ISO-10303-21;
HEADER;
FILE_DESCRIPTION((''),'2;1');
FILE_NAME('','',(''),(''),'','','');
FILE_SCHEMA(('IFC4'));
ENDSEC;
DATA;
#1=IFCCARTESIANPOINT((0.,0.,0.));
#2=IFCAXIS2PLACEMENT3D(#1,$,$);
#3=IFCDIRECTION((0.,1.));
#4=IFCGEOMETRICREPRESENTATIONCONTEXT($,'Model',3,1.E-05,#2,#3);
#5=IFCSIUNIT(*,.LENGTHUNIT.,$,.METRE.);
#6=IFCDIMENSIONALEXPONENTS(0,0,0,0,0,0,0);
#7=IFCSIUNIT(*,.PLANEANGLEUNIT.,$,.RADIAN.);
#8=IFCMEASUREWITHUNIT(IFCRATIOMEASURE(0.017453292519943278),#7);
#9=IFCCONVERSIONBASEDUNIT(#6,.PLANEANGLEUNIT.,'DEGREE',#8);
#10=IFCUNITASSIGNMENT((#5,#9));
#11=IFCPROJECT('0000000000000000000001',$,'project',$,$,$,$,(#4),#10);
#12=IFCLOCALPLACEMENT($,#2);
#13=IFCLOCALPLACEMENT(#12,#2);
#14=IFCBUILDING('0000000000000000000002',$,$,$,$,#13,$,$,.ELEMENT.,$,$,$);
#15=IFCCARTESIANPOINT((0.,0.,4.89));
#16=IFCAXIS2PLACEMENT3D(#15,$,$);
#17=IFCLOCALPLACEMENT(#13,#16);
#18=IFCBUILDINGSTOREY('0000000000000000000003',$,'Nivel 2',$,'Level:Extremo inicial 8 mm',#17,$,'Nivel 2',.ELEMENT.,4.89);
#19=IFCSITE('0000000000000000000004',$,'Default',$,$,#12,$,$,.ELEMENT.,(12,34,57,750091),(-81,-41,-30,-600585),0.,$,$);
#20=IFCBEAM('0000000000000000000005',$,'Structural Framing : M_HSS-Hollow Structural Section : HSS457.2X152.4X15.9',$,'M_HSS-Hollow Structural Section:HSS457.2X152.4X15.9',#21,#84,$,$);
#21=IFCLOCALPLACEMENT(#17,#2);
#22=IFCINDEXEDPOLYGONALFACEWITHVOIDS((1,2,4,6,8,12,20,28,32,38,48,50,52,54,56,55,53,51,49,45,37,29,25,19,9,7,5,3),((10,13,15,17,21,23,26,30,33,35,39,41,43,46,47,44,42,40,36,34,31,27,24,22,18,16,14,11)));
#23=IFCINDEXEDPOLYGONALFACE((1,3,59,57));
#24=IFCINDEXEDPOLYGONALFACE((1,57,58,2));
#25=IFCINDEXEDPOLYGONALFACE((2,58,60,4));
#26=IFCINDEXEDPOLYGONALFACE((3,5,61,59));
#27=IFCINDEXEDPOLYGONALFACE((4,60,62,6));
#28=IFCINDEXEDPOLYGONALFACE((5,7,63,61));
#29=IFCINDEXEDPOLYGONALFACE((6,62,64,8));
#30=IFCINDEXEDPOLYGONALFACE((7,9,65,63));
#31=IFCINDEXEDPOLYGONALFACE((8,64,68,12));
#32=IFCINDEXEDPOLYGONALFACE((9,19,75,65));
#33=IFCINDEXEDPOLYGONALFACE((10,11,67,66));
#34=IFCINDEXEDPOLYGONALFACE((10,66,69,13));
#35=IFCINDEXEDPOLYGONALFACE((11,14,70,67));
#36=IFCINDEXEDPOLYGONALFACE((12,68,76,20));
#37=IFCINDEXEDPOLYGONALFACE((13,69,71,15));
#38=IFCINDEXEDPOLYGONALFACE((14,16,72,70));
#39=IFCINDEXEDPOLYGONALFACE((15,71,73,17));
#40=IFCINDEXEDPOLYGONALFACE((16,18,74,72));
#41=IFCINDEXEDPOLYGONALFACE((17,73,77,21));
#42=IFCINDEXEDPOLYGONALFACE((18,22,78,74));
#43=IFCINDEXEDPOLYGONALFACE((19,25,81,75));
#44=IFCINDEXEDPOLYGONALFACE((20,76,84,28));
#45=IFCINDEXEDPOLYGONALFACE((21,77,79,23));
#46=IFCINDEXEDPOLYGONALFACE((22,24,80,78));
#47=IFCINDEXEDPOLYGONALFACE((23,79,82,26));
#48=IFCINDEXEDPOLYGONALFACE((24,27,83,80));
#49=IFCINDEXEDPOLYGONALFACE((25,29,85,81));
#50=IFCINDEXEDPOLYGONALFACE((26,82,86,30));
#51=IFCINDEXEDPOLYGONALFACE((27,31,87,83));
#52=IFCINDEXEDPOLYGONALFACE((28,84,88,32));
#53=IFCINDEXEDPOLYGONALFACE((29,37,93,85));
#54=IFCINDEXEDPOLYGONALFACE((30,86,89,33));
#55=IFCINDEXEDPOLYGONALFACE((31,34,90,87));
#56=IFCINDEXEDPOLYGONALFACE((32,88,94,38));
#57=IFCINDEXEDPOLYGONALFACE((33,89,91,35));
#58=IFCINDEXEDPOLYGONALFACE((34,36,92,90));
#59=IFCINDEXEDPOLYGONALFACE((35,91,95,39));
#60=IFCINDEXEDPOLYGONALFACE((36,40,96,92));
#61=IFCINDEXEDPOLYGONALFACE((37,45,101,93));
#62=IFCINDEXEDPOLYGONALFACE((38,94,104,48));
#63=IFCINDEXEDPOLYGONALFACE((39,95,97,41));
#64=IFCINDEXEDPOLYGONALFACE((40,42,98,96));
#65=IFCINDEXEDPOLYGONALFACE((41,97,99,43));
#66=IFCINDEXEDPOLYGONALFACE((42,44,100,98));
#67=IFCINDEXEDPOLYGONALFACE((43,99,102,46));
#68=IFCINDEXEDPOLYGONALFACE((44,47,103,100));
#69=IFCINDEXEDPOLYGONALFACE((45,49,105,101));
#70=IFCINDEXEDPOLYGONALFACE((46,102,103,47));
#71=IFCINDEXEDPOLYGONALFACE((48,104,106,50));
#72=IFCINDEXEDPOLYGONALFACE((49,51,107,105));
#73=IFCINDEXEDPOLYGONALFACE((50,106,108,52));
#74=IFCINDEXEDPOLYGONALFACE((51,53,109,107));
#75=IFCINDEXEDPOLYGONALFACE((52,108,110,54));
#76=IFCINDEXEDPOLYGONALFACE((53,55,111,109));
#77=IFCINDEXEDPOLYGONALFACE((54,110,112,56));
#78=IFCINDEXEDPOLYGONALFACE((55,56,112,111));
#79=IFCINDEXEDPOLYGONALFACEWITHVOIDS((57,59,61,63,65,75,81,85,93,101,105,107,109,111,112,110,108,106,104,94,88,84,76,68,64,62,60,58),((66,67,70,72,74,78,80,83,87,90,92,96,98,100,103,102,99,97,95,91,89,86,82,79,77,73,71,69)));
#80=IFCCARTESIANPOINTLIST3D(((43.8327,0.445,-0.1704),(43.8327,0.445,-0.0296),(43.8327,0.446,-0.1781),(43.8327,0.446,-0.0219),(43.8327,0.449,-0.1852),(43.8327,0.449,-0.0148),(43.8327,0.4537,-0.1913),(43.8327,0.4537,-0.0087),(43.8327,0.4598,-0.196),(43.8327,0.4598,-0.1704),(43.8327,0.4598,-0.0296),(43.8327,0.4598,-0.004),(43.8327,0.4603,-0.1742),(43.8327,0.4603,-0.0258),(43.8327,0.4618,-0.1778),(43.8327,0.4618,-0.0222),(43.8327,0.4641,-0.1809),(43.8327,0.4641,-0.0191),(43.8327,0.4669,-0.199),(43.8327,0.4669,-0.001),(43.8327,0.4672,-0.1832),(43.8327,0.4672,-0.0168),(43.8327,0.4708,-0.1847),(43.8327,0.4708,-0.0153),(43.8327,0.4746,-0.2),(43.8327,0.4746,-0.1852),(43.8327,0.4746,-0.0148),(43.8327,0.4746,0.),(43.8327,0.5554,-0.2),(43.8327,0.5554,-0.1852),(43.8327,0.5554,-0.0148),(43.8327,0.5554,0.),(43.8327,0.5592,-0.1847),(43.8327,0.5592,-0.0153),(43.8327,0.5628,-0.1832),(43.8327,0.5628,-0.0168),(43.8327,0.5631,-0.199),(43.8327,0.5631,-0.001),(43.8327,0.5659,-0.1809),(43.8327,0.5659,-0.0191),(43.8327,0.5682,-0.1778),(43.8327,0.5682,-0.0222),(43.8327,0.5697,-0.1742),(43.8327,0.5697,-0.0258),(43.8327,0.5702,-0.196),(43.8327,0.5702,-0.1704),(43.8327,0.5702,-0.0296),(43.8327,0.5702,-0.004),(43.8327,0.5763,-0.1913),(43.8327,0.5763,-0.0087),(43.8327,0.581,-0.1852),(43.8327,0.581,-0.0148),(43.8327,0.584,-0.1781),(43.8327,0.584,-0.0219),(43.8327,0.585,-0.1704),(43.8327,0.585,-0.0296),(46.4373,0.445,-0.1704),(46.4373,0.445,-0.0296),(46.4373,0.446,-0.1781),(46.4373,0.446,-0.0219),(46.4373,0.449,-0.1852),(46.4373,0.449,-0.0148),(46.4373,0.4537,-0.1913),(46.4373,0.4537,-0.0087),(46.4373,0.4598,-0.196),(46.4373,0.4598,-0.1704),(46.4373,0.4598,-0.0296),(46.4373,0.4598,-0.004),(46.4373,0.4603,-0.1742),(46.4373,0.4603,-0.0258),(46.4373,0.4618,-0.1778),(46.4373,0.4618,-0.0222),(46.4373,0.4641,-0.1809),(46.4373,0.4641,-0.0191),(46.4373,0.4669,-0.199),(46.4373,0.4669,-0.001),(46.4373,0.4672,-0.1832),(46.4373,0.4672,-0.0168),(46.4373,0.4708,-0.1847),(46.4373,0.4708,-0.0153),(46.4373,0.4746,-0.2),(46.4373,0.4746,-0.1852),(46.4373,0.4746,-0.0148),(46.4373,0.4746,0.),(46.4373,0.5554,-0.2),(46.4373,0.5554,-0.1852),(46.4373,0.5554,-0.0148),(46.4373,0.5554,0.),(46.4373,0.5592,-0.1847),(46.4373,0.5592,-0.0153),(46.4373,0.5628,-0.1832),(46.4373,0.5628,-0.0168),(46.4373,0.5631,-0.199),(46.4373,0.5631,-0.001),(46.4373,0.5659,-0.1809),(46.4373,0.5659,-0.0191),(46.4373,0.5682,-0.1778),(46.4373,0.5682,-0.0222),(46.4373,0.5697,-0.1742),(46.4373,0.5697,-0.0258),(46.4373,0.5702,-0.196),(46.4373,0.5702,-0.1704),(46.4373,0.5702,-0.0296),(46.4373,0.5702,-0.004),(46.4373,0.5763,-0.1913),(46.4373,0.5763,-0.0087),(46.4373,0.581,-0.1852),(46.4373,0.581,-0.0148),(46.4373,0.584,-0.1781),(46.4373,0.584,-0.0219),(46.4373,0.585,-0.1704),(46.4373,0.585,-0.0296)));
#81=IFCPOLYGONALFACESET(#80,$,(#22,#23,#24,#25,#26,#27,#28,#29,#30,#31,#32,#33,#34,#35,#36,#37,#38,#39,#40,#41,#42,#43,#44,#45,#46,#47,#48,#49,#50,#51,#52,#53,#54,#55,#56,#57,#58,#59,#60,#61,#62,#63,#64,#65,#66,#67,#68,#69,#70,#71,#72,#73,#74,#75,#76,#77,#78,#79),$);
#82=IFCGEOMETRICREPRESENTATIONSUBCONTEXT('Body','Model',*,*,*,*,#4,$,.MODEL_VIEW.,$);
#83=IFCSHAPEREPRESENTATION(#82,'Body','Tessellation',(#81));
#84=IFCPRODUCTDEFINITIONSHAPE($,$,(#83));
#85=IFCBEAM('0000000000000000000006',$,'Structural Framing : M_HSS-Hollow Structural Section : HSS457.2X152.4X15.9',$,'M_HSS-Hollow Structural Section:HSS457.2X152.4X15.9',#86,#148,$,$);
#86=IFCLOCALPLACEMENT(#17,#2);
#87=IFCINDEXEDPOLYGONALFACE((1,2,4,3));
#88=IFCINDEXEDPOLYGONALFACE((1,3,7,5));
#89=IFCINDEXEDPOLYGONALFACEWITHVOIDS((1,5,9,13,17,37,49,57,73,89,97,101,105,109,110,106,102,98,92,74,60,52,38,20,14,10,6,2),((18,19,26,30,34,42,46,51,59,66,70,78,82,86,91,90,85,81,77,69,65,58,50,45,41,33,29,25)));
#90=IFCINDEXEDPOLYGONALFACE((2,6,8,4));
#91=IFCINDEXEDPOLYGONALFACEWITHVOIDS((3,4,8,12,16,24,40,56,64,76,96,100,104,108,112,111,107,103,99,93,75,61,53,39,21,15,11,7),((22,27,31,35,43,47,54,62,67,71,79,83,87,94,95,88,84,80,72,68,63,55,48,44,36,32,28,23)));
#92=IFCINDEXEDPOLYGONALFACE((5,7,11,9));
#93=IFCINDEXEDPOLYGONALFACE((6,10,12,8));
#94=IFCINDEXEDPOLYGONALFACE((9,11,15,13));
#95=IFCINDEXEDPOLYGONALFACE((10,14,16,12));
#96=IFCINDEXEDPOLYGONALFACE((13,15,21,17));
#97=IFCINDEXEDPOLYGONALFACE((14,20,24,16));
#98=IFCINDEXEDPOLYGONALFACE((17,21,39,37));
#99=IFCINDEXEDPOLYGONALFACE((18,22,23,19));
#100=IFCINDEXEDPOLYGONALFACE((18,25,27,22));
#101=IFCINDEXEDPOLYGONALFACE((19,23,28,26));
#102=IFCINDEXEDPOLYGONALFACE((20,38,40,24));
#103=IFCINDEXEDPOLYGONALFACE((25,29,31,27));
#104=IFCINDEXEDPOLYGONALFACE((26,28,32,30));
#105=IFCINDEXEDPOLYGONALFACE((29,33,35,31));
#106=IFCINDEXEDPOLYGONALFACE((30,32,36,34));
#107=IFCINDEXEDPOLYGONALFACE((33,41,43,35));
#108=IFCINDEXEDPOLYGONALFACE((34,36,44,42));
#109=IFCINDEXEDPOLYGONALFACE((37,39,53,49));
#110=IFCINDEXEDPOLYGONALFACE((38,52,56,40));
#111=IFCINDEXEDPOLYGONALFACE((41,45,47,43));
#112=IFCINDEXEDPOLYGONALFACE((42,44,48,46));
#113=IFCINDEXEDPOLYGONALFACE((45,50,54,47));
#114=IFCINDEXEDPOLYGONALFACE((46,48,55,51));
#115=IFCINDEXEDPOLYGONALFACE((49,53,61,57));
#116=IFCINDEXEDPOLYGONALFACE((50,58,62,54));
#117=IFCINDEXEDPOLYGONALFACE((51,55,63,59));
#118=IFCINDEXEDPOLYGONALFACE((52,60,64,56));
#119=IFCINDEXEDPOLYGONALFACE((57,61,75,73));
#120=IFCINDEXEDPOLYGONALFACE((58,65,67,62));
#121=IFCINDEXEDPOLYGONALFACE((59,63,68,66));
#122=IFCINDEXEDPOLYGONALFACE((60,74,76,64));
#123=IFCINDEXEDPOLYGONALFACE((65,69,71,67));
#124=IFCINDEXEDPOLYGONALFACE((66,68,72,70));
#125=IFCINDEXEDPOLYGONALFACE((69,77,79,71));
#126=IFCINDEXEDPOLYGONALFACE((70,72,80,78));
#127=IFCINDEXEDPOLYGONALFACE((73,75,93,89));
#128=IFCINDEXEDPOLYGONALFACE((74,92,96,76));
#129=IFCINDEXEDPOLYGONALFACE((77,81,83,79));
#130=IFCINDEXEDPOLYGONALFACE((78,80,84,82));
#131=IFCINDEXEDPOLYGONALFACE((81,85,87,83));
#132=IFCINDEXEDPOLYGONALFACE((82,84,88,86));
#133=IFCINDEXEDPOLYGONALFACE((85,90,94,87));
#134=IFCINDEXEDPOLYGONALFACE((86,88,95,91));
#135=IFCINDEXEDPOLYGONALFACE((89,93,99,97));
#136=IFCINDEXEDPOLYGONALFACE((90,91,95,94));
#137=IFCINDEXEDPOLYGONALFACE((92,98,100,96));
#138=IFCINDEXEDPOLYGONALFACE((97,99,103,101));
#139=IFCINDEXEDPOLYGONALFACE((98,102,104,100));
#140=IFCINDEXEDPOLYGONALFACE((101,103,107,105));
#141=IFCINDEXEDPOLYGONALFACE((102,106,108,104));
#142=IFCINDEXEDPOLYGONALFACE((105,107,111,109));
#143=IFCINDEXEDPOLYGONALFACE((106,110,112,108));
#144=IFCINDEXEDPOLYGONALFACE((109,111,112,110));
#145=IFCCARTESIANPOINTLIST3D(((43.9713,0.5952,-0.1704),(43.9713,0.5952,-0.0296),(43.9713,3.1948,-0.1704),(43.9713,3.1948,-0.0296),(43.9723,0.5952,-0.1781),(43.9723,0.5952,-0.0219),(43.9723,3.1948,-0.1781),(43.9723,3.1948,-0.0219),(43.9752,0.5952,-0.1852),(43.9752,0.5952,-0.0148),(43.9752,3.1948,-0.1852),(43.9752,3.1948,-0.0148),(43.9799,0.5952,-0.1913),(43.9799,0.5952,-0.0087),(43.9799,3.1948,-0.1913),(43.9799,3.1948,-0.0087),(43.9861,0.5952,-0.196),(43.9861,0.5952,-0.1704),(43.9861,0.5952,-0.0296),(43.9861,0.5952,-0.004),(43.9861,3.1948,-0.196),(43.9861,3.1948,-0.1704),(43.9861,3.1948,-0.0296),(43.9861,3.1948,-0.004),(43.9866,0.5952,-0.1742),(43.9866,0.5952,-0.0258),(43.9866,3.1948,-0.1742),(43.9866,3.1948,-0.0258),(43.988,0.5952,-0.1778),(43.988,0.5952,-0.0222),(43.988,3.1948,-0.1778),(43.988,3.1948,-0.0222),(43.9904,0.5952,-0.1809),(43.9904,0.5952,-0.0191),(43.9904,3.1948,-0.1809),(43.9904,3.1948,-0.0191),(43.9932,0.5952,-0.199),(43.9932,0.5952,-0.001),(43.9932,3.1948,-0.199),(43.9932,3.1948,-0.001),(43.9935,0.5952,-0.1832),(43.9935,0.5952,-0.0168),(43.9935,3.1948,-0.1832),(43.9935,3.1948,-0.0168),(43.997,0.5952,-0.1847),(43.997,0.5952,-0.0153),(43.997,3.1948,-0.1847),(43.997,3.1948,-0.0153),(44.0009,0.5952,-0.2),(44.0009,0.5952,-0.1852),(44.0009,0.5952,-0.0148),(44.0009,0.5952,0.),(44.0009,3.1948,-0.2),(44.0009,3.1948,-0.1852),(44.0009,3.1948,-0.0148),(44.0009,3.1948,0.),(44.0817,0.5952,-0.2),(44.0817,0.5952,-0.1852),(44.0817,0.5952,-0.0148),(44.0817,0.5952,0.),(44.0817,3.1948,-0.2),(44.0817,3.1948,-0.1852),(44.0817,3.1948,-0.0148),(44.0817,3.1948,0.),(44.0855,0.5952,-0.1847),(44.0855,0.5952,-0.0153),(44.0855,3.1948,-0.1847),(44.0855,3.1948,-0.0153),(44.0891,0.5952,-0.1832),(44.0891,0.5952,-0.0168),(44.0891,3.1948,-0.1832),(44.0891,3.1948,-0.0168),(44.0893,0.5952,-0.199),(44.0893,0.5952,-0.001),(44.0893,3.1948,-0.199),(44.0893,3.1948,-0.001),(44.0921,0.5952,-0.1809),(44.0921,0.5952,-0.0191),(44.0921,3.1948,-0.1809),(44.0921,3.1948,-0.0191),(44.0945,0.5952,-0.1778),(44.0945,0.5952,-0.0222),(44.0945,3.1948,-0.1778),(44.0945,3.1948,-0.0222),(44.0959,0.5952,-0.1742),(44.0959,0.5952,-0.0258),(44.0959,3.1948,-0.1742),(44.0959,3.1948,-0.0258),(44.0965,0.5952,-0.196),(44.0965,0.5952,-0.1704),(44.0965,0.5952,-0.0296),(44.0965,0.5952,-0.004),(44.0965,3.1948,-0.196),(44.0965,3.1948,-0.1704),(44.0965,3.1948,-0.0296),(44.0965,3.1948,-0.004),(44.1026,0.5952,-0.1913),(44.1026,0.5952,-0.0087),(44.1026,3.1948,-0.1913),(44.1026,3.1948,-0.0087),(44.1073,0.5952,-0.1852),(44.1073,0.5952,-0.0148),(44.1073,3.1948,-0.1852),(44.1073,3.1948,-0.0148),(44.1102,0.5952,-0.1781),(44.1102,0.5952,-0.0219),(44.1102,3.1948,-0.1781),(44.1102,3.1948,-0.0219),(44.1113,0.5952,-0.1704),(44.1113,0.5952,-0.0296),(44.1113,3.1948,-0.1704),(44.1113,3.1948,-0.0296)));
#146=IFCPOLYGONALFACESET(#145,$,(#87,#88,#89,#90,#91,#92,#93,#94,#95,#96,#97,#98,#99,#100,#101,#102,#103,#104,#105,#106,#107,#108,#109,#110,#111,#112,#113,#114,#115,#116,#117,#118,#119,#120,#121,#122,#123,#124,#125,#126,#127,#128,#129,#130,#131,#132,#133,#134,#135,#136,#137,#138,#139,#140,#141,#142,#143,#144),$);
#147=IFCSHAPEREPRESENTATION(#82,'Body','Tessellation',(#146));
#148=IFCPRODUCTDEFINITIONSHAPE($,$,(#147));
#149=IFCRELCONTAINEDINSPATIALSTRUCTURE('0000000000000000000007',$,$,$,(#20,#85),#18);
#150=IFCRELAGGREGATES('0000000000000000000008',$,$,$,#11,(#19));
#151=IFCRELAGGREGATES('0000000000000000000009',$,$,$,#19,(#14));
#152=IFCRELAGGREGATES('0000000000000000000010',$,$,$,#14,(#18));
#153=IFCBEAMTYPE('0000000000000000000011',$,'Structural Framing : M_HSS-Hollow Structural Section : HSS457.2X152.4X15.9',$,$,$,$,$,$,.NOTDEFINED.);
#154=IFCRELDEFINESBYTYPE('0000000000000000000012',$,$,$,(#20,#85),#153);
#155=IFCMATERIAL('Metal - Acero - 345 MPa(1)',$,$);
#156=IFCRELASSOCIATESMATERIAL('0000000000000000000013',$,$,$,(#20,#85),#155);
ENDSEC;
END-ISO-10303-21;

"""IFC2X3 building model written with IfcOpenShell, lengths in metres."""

from ifc_helpers import new_model, entity, si_unit, converted_unit, direction, frame, frame_2d, origin, place, context, subcontext, project, spatial, polyline, circle_curve, parameter, trimmed, segment, composite_curve, outline, extrude, material, type_object, element, save


model = new_model("IFC2X3")

# Units and contexts
model_context = context("Model", 3, precision=1e-05, world=origin(), true_north=direction((0.0, 1.0)))
body_context = subcontext(model_context, "Body", "Model", "MODEL_VIEW")
ifc_project = project(units=[si_unit("LENGTHUNIT", "METRE"), converted_unit("PLANEANGLEUNIT", "DEGREE", entity("IfcRatioMeasure", 0.017453292519943278), si_unit("PLANEANGLEUNIT", "RADIAN"), dimensions=[0, 0, 0, 0, 0, 0, 0])], contexts=[model_context])

# Site, building, storey
site_placement = place(None, origin())
site = spatial("IfcSite", under=ifc_project, at=site_placement, Name="Default", CompositionType="ELEMENT", RefLatitude=(12, 34, 57, 750091), RefLongitude=(-81, -41, -30, -600585), RefElevation=0.0)
building_placement = place(site_placement, origin())
building = spatial("IfcBuilding", under=site, at=building_placement, CompositionType="ELEMENT")
storey_placement = place(building_placement, frame((0.0, 0.0, 4.89)))
storey = spatial("IfcBuildingStorey", under=building, at=storey_placement, Name="Nivel 2", ObjectType="Level:Extremo inicial 8 mm", LongName="Nivel 2", CompositionType="ELEMENT", Elevation=4.89)

# Shared definitions
ifc_material_1 = material(Name="Metal - Acero - 345 MPa(1)")

# Beams
beam_type_1 = type_object("IfcBeamType", Name="Structural Framing : M_HSS-Hollow Structural Section : HSS457.2X152.4X15.9", PredefinedType="NOTDEFINED")
beam_1_placement = place(storey_placement, frame((43.74, 0.515, 0.0)))
element("IfcBeam", 1, at=beam_1_placement, inside=storey, type_object=beam_type_1, material=ifc_material_1, Name="Structural Framing : M_HSS-Hollow Structural Section : HSS457.2X152.4X15.9", ObjectType="M_HSS-Hollow Structural Section:HSS457.2X152.4X15.9", context=body_context, shape_type="SweptSolid", body=[
    extrude(outline(composite_curve([segment(polyline([(-0.0704, -0.07), (0.0704, -0.07)]), True, "CONTINUOUS"), segment(trimmed(circle_curve(frame_2d((0.0704, -0.0404), x_axis=(0.0, 1.0)), 0.0296), [parameter(180.0)], [parameter(270.0)], True, "PARAMETER"), True, "CONTINUOUS"), segment(polyline([(0.1, -0.0404), (0.1, 0.0404)]), True, "CONTINUOUS"), segment(trimmed(circle_curve(frame_2d((0.0704, 0.0404), x_axis=(0.0, 1.0)), 0.0296), [parameter(270.0)], [parameter(0.0)], True, "PARAMETER"), True, "CONTINUOUS"), segment(polyline([(0.0704, 0.07), (-0.0704, 0.07)]), True, "CONTINUOUS"), segment(trimmed(circle_curve(frame_2d((-0.0704, 0.0404), x_axis=(0.0, 1.0)), 0.0296), [parameter(360.0)], [parameter(90.0)], True, "PARAMETER"), True, "CONTINUOUS"), segment(polyline([(-0.1, 0.0404), (-0.1, -0.0404)]), True, "CONTINUOUS"), segment(trimmed(circle_curve(frame_2d((-0.0704, -0.0404), x_axis=(0.0, 1.0)), 0.0296), [parameter(90.0)], [parameter(180.0)], True, "PARAMETER"), True, "CONTINUOUS")], self_intersect=False), holes=[composite_curve([segment(trimmed(circle_curve(frame_2d((-0.0704, 0.0404), x_axis=(0.0, 1.0)), 0.0148), [parameter(360.0)], [parameter(90.0)], True, "PARAMETER"), False, "CONTINUOUS"), segment(polyline([(-0.0704, 0.0552), (0.0704, 0.0552)]), True, "CONTINUOUS"), segment(trimmed(circle_curve(frame_2d((0.0704, 0.0404), x_axis=(0.0, 1.0)), 0.0148), [parameter(270.0)], [parameter(0.0)], True, "PARAMETER"), False, "CONTINUOUS"), segment(polyline([(0.0852, 0.0404), (0.0852, -0.0404)]), True, "CONTINUOUS"), segment(trimmed(circle_curve(frame_2d((0.0704, -0.0404), x_axis=(0.0, 1.0)), 0.0148), [parameter(180.0)], [parameter(270.0)], True, "PARAMETER"), False, "CONTINUOUS"), segment(polyline([(0.0704, -0.0552), (-0.0704, -0.0552)]), True, "CONTINUOUS"), segment(trimmed(circle_curve(frame_2d((-0.0704, -0.0404), x_axis=(0.0, 1.0)), 0.0148), [parameter(90.0)], [parameter(180.0)], True, "PARAMETER"), False, "CONTINUOUS"), segment(polyline([(-0.0852, -0.0404), (-0.0852, 0.0404)]), True, "CONTINUOUS")], self_intersect=False)]), frame((0.0927, 0.0, -0.1), z_axis=(1.0, 0.0, 0.0), x_axis=(0.0, 0.0, -1.0)), (0.0, 0.0, 1.0), 2.6046),
])
beam_2_placement = place(storey_placement, frame((44.0413, 3.275, 0.0), z_axis=(0.0, 0.0, 1.0), x_axis=(0.0, -1.0, 0.0)))
element("IfcBeam", 2, at=beam_2_placement, inside=storey, type_object=beam_type_1, material=ifc_material_1, Name="Structural Framing : M_HSS-Hollow Structural Section : HSS457.2X152.4X15.9", ObjectType="M_HSS-Hollow Structural Section:HSS457.2X152.4X15.9", context=body_context, shape_type="SweptSolid", body=[
    extrude(outline(composite_curve([segment(trimmed(circle_curve(frame_2d((-0.0404, -0.0704), x_axis=(1.0, 0.0)), 0.0296), [parameter(180.0)], [parameter(270.0)], True, "PARAMETER"), True, "CONTINUOUS"), segment(polyline([(-0.0404, -0.1), (0.0404, -0.1)]), True, "CONTINUOUS"), segment(trimmed(circle_curve(frame_2d((0.0404, -0.0704), x_axis=(1.0, 0.0)), 0.0296), [parameter(270.0)], [parameter(0.0)], True, "PARAMETER"), True, "CONTINUOUS"), segment(polyline([(0.07, -0.0704), (0.07, 0.0704)]), True, "CONTINUOUS"), segment(trimmed(circle_curve(frame_2d((0.0404, 0.0704), x_axis=(1.0, 0.0)), 0.0296), [parameter(360.0)], [parameter(90.0)], True, "PARAMETER"), True, "CONTINUOUS"), segment(polyline([(0.0404, 0.1), (-0.0404, 0.1)]), True, "CONTINUOUS"), segment(trimmed(circle_curve(frame_2d((-0.0404, 0.0704), x_axis=(1.0, 0.0)), 0.0296), [parameter(90.0)], [parameter(180.0)], True, "PARAMETER"), True, "CONTINUOUS"), segment(polyline([(-0.07, 0.0704), (-0.07, -0.0704)]), True, "CONTINUOUS")], self_intersect=False), holes=[composite_curve([segment(polyline([(0.0404, -0.0852), (-0.0404, -0.0852)]), True, "CONTINUOUS"), segment(trimmed(circle_curve(frame_2d((-0.0404, -0.0704), x_axis=(1.0, 0.0)), 0.0148), [parameter(180.0)], [parameter(270.0)], True, "PARAMETER"), False, "CONTINUOUS"), segment(polyline([(-0.0552, -0.0704), (-0.0552, 0.0704)]), True, "CONTINUOUS"), segment(trimmed(circle_curve(frame_2d((-0.0404, 0.0704), x_axis=(1.0, 0.0)), 0.0148), [parameter(90.0)], [parameter(180.0)], True, "PARAMETER"), False, "CONTINUOUS"), segment(polyline([(-0.0404, 0.0852), (0.0404, 0.0852)]), True, "CONTINUOUS"), segment(trimmed(circle_curve(frame_2d((0.0404, 0.0704), x_axis=(1.0, 0.0)), 0.0148), [parameter(0.0)], [parameter(90.0)], True, "PARAMETER"), False, "CONTINUOUS"), segment(polyline([(0.0552, 0.0704), (0.0552, -0.0704)]), True, "CONTINUOUS"), segment(trimmed(circle_curve(frame_2d((0.0404, -0.0704), x_axis=(1.0, 0.0)), 0.0148), [parameter(270.0)], [parameter(0.0)], True, "PARAMETER"), False, "CONTINUOUS")], self_intersect=False)]), frame((0.0802, 0.0, -0.1), z_axis=(1.0, 0.0, 0.0), x_axis=(0.0, -1.0, 0.0)), (0.0, 0.0, 1.0), 2.5996),
])

save(model, "model.ifc")
